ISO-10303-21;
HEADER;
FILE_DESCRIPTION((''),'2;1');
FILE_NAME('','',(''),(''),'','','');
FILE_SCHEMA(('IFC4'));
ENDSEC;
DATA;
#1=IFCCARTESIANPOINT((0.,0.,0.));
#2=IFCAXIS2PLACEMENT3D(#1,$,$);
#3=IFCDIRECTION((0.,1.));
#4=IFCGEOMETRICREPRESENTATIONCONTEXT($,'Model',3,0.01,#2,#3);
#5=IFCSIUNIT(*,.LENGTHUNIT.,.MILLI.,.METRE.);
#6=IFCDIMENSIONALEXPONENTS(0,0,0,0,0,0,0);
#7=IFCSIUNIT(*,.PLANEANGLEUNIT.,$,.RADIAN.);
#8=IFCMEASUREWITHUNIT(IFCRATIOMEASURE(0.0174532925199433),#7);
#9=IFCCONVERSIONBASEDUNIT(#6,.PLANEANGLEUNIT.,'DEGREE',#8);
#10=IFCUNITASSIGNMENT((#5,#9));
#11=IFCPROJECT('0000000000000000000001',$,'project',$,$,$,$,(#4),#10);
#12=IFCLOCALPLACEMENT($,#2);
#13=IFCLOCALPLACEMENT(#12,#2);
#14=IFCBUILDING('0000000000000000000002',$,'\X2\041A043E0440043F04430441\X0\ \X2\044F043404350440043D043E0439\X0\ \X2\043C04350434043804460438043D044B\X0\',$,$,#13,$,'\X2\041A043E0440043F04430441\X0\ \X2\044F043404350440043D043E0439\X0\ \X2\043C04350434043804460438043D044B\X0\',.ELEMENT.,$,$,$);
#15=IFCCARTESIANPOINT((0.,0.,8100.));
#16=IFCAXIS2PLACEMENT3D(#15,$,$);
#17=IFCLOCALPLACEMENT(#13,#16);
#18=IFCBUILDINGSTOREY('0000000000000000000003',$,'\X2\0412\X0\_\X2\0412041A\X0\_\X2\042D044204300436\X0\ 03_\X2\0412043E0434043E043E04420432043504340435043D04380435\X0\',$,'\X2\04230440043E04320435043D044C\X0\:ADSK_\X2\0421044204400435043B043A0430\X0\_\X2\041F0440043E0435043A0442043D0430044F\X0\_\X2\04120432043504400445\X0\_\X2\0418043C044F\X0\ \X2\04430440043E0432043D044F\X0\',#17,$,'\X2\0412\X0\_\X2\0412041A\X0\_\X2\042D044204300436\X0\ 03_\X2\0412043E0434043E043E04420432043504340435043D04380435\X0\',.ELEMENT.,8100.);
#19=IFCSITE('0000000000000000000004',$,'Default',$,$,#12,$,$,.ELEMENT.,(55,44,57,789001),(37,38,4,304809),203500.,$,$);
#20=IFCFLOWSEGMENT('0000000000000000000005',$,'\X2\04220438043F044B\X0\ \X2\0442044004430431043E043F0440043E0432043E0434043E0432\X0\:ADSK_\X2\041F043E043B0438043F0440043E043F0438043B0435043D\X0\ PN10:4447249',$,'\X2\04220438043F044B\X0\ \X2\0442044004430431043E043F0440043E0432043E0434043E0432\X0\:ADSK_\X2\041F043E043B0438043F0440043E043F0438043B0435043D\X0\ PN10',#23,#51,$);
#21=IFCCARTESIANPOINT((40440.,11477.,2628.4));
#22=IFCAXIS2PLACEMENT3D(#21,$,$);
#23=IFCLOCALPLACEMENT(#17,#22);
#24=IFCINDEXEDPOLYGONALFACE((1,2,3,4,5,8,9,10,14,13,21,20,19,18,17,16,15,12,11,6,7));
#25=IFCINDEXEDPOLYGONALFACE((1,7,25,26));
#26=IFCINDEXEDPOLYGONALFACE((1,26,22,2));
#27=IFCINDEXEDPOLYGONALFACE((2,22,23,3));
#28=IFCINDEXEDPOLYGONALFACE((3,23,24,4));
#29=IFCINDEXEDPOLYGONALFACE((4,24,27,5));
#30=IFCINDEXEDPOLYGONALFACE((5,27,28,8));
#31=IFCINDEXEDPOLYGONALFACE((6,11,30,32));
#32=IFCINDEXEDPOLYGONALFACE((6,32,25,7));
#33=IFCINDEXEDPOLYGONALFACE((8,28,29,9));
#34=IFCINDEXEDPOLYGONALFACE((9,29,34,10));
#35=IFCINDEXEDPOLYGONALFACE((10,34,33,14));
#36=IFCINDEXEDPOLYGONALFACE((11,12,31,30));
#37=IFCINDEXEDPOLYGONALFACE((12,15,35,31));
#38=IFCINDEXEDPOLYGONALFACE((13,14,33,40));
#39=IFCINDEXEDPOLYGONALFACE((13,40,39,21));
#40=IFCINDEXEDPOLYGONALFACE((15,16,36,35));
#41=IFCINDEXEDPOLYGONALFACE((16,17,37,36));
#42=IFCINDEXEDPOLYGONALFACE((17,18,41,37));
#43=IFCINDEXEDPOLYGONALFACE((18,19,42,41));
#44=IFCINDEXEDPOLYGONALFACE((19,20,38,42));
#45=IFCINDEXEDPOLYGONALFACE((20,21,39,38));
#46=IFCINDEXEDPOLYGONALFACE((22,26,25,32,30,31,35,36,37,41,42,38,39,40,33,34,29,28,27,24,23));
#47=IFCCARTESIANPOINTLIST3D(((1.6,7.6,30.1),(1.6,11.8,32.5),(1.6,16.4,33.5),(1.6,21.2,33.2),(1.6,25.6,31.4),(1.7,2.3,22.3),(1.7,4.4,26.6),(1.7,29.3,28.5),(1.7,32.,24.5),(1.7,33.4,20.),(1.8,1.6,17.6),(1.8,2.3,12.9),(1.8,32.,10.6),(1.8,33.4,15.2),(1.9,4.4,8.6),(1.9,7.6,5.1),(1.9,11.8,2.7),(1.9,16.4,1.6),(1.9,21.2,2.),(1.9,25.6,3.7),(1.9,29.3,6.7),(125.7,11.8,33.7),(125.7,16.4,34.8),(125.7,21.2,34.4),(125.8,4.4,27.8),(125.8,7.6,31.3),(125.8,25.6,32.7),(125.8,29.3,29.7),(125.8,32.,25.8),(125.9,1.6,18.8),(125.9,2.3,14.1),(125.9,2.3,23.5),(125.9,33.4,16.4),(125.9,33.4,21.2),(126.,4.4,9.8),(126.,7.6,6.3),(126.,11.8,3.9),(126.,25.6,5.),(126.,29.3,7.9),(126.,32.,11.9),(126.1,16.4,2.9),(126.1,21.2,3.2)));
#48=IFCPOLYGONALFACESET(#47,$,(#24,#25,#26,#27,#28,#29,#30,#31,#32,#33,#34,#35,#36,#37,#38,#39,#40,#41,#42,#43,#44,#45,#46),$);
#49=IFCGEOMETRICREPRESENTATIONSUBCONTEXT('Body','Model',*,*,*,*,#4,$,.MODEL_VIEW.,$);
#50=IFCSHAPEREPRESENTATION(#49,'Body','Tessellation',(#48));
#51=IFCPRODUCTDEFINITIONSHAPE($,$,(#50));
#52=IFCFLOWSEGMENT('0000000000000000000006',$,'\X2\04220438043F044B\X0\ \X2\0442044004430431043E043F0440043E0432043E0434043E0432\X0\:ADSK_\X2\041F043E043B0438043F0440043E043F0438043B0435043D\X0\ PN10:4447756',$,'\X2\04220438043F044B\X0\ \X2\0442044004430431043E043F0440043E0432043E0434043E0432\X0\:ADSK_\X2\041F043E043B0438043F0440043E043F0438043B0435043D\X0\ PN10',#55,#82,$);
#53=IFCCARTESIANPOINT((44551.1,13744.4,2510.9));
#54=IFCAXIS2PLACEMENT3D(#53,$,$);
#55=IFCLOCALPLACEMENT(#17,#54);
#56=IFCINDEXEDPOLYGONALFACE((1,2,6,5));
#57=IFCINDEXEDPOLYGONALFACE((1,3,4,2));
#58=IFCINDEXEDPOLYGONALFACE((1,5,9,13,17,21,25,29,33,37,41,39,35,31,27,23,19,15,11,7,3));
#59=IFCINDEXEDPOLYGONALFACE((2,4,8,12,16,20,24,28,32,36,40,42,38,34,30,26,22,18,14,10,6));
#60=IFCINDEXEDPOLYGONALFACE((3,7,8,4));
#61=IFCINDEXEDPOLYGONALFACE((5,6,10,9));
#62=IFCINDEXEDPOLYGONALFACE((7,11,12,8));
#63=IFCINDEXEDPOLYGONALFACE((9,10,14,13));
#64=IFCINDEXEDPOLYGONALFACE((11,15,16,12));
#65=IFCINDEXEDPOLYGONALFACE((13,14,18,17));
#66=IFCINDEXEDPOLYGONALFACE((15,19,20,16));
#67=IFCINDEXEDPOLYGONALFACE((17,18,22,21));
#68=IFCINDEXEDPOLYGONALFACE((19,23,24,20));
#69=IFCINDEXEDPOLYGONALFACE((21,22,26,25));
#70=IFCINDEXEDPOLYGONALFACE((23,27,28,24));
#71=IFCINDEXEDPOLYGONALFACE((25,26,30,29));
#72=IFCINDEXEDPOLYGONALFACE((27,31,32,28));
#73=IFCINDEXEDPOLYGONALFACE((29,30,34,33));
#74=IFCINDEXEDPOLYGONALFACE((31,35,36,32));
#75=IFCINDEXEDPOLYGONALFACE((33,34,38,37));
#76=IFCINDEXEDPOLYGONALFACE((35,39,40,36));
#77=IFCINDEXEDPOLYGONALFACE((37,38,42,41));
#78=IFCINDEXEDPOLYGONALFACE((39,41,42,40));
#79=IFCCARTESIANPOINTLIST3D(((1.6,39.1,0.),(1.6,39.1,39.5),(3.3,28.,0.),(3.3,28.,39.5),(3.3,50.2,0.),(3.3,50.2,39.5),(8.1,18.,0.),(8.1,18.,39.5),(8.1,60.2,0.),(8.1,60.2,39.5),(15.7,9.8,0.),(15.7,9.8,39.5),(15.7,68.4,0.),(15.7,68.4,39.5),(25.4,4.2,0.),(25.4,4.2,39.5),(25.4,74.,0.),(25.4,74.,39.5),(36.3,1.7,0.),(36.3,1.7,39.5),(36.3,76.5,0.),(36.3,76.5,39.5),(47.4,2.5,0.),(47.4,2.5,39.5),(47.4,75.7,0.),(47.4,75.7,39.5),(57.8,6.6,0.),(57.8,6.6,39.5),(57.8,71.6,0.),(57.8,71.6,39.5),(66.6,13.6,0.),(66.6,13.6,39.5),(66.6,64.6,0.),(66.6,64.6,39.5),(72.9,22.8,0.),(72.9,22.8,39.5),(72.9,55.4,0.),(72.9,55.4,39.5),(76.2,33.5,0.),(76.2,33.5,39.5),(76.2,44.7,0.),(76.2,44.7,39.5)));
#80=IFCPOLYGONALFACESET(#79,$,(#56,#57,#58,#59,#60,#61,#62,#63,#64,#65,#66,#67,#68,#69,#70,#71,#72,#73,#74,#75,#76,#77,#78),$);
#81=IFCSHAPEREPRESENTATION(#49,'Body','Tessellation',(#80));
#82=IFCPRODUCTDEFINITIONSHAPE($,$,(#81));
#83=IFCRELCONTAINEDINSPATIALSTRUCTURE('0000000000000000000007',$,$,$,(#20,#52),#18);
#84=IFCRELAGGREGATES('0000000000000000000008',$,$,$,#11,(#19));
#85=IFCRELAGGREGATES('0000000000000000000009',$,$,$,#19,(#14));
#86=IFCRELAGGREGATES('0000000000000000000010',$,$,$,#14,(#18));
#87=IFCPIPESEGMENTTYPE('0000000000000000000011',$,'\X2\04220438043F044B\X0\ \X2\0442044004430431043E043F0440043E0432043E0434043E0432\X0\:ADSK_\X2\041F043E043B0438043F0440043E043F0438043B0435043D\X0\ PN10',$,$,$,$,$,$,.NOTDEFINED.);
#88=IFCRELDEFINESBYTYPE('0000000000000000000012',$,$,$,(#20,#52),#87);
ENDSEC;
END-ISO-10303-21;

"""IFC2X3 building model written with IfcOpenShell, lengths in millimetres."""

from ifc_helpers import new_model, entity, si_unit, converted_unit, direction, frame, origin, origin_2d_with_axis, place, context, subcontext, project, spatial, circle, extrude, type_object, element, save


model = new_model("IFC2X3")

# Units and contexts
model_context = context("Model", 3, precision=0.01, world=origin(), true_north=direction((0.0, 1.0)))
body_context = subcontext(model_context, "Body", "Model", "MODEL_VIEW")
ifc_project = project(units=[si_unit("LENGTHUNIT", "METRE", prefix="MILLI"), converted_unit("PLANEANGLEUNIT", "DEGREE", entity("IfcRatioMeasure", 0.0174532925199433), si_unit("PLANEANGLEUNIT", "RADIAN"), dimensions=[0, 0, 0, 0, 0, 0, 0])], contexts=[model_context])

# Site, building, storey
site_placement = place(None, origin())
site = spatial("IfcSite", under=ifc_project, at=site_placement, Name="Default", CompositionType="ELEMENT", RefLatitude=(55, 44, 57, 789001), RefLongitude=(37, 38, 4, 304809), RefElevation=203500.0)
building_placement = place(site_placement, origin())
building = spatial("IfcBuilding", under=site, at=building_placement, Name="Корпус ядерной медицины", LongName="Корпус ядерной медицины", CompositionType="ELEMENT")
storey_placement = place(building_placement, frame((0.0, 0.0, 8100.0)))
storey = spatial("IfcBuildingStorey", under=building, at=storey_placement, Name="В_ВК_Этаж 03_Водоотведение", ObjectType="Уровень:ADSK_Стрелка_Проектная_Вверх_Имя уровня", LongName="В_ВК_Этаж 03_Водоотведение", CompositionType="ELEMENT", Elevation=8100.0)

# Flow segments
pipe_segment_type_1 = type_object("IfcPipeSegmentType", Name="Типы трубопроводов:ADSK_Полипропилен PN10", PredefinedType="NOTDEFINED")
flow_segment_1_placement = place(storey_placement, frame((40440.0, 11477.0, 2628.4)))
element("IfcFlowSegment", 1, at=flow_segment_1_placement, inside=storey, type_object=pipe_segment_type_1, Name="Типы трубопроводов:ADSK_Полипропилен PN10:4447249", ObjectType="Типы трубопроводов:ADSK_Полипропилен PN10", context=body_context, shape_type="SweptSolid", body=[
    extrude(circle(Radius=16.0, at=origin_2d_with_axis()), frame((1.8, 17.6, 17.6), z_axis=(0.99995, 0.0, 0.01), x_axis=(0.0, -1.0, 0.0)), (0.0, 0.0, 1.0), 124.1),
])
flow_segment_2_placement = place(storey_placement, frame((44551.1, 13744.4, 2510.9)))
element("IfcFlowSegment", 2, at=flow_segment_2_placement, inside=storey, type_object=pipe_segment_type_1, Name="Типы трубопроводов:ADSK_Полипропилен PN10:4447756", ObjectType="Типы трубопроводов:ADSK_Полипропилен PN10", context=body_context, shape_type="SweptSolid", body=[
    extrude(circle(Radius=37.5, at=origin_2d_with_axis()), frame((39.1, 39.1, 0.0), z_axis=(0.0, 0.0, 1.0), x_axis=(-1.0, 0.0, 0.0)), (0.0, 0.0, 1.0), 39.5),
])

save(model, "model.ifc")
